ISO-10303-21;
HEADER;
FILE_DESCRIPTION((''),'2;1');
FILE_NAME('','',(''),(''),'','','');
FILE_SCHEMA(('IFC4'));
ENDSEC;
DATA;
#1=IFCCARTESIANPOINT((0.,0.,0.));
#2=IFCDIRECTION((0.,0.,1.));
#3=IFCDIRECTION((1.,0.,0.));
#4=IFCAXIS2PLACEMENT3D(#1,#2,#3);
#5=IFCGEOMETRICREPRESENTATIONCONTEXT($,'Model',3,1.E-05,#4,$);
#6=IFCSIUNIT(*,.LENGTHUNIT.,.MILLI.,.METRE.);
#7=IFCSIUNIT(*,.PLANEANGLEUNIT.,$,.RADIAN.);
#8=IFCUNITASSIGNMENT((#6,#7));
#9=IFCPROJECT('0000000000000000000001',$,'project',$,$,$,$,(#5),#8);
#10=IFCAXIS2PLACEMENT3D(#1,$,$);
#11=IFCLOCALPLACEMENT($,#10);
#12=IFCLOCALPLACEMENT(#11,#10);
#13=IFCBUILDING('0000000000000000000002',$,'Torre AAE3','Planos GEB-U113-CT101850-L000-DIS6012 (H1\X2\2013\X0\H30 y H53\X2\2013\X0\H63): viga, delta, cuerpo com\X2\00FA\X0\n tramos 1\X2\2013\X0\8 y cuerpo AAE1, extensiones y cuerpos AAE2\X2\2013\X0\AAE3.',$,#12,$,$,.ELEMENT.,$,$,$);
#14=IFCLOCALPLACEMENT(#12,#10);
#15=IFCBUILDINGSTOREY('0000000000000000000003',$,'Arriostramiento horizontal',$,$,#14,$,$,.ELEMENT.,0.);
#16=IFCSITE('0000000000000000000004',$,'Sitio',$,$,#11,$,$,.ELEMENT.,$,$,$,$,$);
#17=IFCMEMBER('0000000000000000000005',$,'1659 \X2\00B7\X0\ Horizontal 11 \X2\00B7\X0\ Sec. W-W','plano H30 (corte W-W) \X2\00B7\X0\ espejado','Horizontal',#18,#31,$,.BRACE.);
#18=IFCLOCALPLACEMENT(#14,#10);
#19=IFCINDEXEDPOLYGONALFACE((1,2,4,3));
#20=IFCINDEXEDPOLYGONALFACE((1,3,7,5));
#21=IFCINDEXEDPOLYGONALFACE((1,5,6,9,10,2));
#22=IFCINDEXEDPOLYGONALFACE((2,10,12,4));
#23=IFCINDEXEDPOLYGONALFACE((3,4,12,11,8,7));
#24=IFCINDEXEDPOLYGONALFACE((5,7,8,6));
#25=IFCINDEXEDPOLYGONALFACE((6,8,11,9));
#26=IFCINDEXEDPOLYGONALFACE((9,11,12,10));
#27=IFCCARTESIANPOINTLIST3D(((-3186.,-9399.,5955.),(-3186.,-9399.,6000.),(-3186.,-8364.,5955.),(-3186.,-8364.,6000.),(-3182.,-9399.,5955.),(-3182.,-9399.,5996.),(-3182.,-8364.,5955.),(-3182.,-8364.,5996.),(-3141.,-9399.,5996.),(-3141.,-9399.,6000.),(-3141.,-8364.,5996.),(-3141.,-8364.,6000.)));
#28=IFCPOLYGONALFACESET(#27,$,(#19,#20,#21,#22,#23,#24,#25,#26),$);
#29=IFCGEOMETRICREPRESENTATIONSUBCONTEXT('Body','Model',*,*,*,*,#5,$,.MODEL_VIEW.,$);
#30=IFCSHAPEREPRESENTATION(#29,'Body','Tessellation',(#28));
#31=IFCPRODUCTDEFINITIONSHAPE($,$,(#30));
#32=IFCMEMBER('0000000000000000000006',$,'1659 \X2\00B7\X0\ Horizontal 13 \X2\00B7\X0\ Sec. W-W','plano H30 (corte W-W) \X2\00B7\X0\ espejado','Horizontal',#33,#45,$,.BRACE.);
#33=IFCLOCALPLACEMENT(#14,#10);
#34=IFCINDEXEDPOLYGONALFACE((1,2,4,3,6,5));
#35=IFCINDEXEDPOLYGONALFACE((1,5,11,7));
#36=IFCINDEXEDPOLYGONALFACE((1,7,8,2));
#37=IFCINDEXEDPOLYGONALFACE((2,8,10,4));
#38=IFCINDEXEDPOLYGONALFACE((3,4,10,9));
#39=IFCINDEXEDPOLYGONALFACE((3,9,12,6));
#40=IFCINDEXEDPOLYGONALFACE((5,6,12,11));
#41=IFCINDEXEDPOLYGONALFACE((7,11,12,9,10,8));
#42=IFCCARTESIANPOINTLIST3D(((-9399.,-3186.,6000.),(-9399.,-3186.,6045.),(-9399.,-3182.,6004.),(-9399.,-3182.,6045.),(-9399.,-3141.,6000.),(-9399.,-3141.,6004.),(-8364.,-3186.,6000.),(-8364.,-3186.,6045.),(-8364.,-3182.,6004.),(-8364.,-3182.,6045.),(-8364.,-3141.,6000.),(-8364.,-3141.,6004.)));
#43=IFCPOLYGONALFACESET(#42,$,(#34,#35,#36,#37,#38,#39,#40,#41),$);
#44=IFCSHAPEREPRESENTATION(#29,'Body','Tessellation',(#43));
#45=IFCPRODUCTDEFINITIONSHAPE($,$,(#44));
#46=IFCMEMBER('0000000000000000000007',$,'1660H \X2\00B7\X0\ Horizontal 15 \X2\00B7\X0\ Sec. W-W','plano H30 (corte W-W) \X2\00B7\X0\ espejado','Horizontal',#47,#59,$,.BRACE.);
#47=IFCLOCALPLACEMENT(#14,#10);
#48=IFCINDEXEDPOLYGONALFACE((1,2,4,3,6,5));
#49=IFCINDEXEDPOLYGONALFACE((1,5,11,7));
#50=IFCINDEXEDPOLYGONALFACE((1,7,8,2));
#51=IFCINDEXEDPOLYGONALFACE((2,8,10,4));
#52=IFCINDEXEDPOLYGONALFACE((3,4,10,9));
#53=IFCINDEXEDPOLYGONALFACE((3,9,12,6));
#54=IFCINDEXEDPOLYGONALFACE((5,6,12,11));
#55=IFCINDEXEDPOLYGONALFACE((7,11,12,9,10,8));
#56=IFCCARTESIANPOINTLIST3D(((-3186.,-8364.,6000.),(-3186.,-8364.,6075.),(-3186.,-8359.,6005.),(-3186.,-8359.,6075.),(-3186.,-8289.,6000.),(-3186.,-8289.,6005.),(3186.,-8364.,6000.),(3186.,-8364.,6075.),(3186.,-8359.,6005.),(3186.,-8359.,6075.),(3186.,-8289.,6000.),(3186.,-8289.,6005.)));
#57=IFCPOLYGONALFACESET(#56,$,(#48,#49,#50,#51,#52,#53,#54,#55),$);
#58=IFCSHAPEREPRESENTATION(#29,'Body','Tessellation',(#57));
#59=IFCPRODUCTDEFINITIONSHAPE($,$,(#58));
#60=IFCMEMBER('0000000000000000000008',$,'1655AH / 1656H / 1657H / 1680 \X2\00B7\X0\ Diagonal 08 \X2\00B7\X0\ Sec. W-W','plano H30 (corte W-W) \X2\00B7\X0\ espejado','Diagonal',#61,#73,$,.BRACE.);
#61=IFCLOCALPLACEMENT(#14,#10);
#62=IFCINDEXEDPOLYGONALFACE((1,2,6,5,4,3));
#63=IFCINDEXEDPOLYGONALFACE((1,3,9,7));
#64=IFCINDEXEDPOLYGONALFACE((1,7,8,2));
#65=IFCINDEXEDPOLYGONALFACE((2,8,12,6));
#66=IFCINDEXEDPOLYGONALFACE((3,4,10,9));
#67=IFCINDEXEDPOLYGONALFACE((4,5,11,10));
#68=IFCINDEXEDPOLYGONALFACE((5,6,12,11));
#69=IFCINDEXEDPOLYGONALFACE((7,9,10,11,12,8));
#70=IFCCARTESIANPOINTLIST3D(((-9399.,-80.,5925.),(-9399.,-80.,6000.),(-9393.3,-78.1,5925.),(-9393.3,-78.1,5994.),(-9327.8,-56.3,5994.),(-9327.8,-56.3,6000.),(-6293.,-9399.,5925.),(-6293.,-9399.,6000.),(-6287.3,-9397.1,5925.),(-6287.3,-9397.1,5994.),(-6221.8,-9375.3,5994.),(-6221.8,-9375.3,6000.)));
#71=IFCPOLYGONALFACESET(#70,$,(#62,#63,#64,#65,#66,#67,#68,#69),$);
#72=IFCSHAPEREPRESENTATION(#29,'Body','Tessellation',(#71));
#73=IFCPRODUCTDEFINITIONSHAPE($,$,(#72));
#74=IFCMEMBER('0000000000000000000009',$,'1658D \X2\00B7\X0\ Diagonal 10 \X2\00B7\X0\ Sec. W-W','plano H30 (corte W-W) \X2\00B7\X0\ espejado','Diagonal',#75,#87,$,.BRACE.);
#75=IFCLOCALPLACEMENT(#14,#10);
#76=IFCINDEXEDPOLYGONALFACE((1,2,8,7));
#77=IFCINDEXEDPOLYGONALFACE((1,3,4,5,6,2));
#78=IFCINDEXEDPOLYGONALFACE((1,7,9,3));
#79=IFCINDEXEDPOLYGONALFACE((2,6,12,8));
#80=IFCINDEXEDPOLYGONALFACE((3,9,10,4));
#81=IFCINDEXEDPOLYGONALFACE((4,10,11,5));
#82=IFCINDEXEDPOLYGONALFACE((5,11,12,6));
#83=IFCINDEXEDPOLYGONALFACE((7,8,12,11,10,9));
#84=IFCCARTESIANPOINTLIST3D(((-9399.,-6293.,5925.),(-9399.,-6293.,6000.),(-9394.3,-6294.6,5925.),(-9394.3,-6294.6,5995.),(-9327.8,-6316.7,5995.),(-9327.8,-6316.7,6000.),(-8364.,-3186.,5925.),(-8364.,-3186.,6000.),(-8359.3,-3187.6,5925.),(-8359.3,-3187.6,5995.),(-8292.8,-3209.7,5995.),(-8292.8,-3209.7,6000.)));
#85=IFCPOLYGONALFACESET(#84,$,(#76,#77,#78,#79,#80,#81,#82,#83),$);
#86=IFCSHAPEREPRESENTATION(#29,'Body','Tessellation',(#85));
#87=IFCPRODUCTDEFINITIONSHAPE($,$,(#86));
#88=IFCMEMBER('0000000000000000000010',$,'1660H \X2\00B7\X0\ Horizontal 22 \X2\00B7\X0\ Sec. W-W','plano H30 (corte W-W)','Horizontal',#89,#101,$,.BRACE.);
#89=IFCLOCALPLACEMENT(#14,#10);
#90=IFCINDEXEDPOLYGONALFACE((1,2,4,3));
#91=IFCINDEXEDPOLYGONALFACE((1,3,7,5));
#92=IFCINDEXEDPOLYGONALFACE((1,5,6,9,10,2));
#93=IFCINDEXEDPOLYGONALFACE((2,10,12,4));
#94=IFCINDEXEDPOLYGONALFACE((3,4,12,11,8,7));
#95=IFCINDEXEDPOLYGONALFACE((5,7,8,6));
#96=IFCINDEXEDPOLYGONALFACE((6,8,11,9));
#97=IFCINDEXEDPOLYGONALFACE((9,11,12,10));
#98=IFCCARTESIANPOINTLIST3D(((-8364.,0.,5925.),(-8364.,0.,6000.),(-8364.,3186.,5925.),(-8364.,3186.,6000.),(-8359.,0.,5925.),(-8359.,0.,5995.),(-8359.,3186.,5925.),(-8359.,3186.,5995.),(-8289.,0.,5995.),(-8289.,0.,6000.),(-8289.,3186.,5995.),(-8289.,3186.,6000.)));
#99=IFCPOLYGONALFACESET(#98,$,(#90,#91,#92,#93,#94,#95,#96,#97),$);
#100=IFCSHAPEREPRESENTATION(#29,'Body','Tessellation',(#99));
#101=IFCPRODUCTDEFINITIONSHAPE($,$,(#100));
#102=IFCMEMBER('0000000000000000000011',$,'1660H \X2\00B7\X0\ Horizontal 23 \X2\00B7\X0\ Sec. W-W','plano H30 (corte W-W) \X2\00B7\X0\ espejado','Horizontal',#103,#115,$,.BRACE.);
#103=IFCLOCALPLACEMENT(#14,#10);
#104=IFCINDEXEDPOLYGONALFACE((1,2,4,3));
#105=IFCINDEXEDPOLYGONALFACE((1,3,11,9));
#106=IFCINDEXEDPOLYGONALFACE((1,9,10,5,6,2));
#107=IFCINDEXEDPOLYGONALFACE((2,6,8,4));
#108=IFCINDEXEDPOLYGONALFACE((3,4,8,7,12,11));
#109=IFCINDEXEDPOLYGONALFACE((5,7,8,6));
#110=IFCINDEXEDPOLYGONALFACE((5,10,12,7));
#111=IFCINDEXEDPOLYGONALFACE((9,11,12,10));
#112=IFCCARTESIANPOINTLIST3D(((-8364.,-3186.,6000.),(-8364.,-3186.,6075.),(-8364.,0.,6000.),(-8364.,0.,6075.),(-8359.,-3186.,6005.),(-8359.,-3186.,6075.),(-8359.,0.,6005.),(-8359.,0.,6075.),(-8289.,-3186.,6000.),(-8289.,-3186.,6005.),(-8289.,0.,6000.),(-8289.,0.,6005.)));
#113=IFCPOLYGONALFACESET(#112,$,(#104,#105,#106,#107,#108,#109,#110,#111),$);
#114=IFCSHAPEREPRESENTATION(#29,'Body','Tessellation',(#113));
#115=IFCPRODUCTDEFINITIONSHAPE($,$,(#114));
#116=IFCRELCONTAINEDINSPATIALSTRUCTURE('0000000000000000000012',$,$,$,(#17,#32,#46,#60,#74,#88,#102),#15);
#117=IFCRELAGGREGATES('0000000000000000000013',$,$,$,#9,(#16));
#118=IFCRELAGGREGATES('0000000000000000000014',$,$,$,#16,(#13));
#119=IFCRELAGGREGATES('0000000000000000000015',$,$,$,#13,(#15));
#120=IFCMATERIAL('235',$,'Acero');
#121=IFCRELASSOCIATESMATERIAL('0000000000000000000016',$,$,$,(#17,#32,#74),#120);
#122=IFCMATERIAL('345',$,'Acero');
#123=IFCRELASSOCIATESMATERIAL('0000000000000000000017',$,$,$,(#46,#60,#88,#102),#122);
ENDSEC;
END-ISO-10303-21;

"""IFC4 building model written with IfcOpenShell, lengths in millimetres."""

from ifc_helpers import new_model, si_unit, frame, frame_2d, origin, origin_with_axes, place, context, subcontext, project, spatial, l_section, extrude, material, element, save


model = new_model("IFC4")

# Units and contexts
model_context = context("Model", 3, precision=1e-05, world=origin_with_axes())
body_context = subcontext(model_context, "Body", "Model", "MODEL_VIEW")
ifc_project = project(units=[si_unit("LENGTHUNIT", "METRE", prefix="MILLI"), si_unit("PLANEANGLEUNIT", "RADIAN")], contexts=[model_context])

# Site, building, storey
site_placement = place(None, origin())
site = spatial("IfcSite", under=ifc_project, at=site_placement, Name="Sitio", CompositionType="ELEMENT")
building_placement = place(site_placement, origin())
building = spatial("IfcBuilding", under=site, at=building_placement, Name="Torre AAE3", Description="Planos GEB-U113-CT101850-L000-DIS6012 (H1–H30 y H53–H63): viga, delta, cuerpo común tramos 1–8 y cuerpo AAE1, extensiones y cuerpos AAE2–AAE3.", CompositionType="ELEMENT")
storey_placement = place(building_placement, origin())
storey = spatial("IfcBuildingStorey", under=building, at=storey_placement, Name="Arriostramiento horizontal", CompositionType="ELEMENT", Elevation=0.0)

# Members
ifc_material_1 = material(Name="235", Category="Acero")
ifc_material_2 = material(Name="345", Category="Acero")
for number, where, z_axis, x_axis, name in (
    (1, (-3186.0, -9399.0, 6000.0), (0.0, 1.0, 0.0), (1.0, 0.0, 0.0), "1659 · Horizontal 11 · Sec. W-W"),
    (2, (-9399.0, -3186.0, 6000.0), (1.0, 0.0, 0.0), (0.0, 1.0, 0.0), "1659 · Horizontal 13 · Sec. W-W"),
):
    element("IfcMember", number, at=place(storey_placement, frame(where, z_axis=z_axis, x_axis=x_axis)), inside=storey, material=ifc_material_1, Name=name, Description="plano H30 (corte W-W) · espejado", ObjectType="Horizontal", PredefinedType="BRACE", context=body_context, shape_type="SweptSolid", body=[
        extrude(l_section(Depth=45.0, Width=45.0, Thickness=4.0, at=frame_2d((22.5, 22.5))), None, (0.0, 0.0, 1.0), 1035.0),
    ])
member_1_placement = place(storey_placement, frame((-3186.0, -8364.0, 6000.0), z_axis=(1.0, 0.0, 0.0), x_axis=(0.0, 1.0, 0.0)))
element("IfcMember", 3, at=member_1_placement, inside=storey, material=ifc_material_2, Name="1660H · Horizontal 15 · Sec. W-W", Description="plano H30 (corte W-W) · espejado", ObjectType="Horizontal", PredefinedType="BRACE", context=body_context, shape_type="SweptSolid", body=[
    extrude(l_section(Depth=75.0, Width=75.0, Thickness=5.0, at=frame_2d((37.5, 37.5))), None, (0.0, 0.0, 1.0), 6372.0),
])
member_2_placement = place(storey_placement, frame((-6293.0, -9399.0, 6000.0), z_axis=(-0.316197, 0.948693, 0.0), x_axis=(0.948693, 0.316197, 0.0)))
element("IfcMember", 4, at=member_2_placement, inside=storey, material=ifc_material_2, Name="1655AH / 1656H / 1657H / 1680 · Diagonal 08 · Sec. W-W", Description="plano H30 (corte W-W) · espejado", ObjectType="Diagonal", PredefinedType="BRACE", context=body_context, shape_type="SweptSolid", body=[
    extrude(l_section(Depth=75.0, Width=75.0, Thickness=6.0, at=frame_2d((37.5, 37.5))), None, (0.0, 0.0, 1.0), 9823.0),
])
member_3_placement = place(storey_placement, frame((-9399.0, -6293.0, 6000.0), z_axis=(0.316045, 0.948744, 0.0), x_axis=(0.948744, -0.316045, 0.0)))
element("IfcMember", 5, at=member_3_placement, inside=storey, material=ifc_material_1, Name="1658D · Diagonal 10 · Sec. W-W", Description="plano H30 (corte W-W) · espejado", ObjectType="Diagonal", PredefinedType="BRACE", context=body_context, shape_type="SweptSolid", body=[
    extrude(l_section(Depth=75.0, Width=75.0, Thickness=5.0, at=frame_2d((37.5, 37.5))), None, (0.0, 0.0, 1.0), 3274.9),
])
for number, where, z_axis, x_axis, name, description in (
    (6, (-8364.0, 0.0, 6000.0), (0.0, 1.0, 0.0), (1.0, 0.0, 0.0), "1660H · Horizontal 22 · Sec. W-W", "plano H30 (corte W-W)"),
    (7, (-8364.0, 0.0, 6000.0), (0.0, -1.0, 0.0), (1.0, 0.0, 0.0), "1660H · Horizontal 23 · Sec. W-W", "plano H30 (corte W-W) · espejado"),
):
    element("IfcMember", number, at=place(storey_placement, frame(where, z_axis=z_axis, x_axis=x_axis)), inside=storey, material=ifc_material_2, Name=name, Description=description, ObjectType="Horizontal", PredefinedType="BRACE", context=body_context, shape_type="SweptSolid", body=[
        extrude(l_section(Depth=75.0, Width=75.0, Thickness=5.0, at=frame_2d((37.5, 37.5))), None, (0.0, 0.0, 1.0), 3186.0),
    ])

save(model, "model.ifc")
